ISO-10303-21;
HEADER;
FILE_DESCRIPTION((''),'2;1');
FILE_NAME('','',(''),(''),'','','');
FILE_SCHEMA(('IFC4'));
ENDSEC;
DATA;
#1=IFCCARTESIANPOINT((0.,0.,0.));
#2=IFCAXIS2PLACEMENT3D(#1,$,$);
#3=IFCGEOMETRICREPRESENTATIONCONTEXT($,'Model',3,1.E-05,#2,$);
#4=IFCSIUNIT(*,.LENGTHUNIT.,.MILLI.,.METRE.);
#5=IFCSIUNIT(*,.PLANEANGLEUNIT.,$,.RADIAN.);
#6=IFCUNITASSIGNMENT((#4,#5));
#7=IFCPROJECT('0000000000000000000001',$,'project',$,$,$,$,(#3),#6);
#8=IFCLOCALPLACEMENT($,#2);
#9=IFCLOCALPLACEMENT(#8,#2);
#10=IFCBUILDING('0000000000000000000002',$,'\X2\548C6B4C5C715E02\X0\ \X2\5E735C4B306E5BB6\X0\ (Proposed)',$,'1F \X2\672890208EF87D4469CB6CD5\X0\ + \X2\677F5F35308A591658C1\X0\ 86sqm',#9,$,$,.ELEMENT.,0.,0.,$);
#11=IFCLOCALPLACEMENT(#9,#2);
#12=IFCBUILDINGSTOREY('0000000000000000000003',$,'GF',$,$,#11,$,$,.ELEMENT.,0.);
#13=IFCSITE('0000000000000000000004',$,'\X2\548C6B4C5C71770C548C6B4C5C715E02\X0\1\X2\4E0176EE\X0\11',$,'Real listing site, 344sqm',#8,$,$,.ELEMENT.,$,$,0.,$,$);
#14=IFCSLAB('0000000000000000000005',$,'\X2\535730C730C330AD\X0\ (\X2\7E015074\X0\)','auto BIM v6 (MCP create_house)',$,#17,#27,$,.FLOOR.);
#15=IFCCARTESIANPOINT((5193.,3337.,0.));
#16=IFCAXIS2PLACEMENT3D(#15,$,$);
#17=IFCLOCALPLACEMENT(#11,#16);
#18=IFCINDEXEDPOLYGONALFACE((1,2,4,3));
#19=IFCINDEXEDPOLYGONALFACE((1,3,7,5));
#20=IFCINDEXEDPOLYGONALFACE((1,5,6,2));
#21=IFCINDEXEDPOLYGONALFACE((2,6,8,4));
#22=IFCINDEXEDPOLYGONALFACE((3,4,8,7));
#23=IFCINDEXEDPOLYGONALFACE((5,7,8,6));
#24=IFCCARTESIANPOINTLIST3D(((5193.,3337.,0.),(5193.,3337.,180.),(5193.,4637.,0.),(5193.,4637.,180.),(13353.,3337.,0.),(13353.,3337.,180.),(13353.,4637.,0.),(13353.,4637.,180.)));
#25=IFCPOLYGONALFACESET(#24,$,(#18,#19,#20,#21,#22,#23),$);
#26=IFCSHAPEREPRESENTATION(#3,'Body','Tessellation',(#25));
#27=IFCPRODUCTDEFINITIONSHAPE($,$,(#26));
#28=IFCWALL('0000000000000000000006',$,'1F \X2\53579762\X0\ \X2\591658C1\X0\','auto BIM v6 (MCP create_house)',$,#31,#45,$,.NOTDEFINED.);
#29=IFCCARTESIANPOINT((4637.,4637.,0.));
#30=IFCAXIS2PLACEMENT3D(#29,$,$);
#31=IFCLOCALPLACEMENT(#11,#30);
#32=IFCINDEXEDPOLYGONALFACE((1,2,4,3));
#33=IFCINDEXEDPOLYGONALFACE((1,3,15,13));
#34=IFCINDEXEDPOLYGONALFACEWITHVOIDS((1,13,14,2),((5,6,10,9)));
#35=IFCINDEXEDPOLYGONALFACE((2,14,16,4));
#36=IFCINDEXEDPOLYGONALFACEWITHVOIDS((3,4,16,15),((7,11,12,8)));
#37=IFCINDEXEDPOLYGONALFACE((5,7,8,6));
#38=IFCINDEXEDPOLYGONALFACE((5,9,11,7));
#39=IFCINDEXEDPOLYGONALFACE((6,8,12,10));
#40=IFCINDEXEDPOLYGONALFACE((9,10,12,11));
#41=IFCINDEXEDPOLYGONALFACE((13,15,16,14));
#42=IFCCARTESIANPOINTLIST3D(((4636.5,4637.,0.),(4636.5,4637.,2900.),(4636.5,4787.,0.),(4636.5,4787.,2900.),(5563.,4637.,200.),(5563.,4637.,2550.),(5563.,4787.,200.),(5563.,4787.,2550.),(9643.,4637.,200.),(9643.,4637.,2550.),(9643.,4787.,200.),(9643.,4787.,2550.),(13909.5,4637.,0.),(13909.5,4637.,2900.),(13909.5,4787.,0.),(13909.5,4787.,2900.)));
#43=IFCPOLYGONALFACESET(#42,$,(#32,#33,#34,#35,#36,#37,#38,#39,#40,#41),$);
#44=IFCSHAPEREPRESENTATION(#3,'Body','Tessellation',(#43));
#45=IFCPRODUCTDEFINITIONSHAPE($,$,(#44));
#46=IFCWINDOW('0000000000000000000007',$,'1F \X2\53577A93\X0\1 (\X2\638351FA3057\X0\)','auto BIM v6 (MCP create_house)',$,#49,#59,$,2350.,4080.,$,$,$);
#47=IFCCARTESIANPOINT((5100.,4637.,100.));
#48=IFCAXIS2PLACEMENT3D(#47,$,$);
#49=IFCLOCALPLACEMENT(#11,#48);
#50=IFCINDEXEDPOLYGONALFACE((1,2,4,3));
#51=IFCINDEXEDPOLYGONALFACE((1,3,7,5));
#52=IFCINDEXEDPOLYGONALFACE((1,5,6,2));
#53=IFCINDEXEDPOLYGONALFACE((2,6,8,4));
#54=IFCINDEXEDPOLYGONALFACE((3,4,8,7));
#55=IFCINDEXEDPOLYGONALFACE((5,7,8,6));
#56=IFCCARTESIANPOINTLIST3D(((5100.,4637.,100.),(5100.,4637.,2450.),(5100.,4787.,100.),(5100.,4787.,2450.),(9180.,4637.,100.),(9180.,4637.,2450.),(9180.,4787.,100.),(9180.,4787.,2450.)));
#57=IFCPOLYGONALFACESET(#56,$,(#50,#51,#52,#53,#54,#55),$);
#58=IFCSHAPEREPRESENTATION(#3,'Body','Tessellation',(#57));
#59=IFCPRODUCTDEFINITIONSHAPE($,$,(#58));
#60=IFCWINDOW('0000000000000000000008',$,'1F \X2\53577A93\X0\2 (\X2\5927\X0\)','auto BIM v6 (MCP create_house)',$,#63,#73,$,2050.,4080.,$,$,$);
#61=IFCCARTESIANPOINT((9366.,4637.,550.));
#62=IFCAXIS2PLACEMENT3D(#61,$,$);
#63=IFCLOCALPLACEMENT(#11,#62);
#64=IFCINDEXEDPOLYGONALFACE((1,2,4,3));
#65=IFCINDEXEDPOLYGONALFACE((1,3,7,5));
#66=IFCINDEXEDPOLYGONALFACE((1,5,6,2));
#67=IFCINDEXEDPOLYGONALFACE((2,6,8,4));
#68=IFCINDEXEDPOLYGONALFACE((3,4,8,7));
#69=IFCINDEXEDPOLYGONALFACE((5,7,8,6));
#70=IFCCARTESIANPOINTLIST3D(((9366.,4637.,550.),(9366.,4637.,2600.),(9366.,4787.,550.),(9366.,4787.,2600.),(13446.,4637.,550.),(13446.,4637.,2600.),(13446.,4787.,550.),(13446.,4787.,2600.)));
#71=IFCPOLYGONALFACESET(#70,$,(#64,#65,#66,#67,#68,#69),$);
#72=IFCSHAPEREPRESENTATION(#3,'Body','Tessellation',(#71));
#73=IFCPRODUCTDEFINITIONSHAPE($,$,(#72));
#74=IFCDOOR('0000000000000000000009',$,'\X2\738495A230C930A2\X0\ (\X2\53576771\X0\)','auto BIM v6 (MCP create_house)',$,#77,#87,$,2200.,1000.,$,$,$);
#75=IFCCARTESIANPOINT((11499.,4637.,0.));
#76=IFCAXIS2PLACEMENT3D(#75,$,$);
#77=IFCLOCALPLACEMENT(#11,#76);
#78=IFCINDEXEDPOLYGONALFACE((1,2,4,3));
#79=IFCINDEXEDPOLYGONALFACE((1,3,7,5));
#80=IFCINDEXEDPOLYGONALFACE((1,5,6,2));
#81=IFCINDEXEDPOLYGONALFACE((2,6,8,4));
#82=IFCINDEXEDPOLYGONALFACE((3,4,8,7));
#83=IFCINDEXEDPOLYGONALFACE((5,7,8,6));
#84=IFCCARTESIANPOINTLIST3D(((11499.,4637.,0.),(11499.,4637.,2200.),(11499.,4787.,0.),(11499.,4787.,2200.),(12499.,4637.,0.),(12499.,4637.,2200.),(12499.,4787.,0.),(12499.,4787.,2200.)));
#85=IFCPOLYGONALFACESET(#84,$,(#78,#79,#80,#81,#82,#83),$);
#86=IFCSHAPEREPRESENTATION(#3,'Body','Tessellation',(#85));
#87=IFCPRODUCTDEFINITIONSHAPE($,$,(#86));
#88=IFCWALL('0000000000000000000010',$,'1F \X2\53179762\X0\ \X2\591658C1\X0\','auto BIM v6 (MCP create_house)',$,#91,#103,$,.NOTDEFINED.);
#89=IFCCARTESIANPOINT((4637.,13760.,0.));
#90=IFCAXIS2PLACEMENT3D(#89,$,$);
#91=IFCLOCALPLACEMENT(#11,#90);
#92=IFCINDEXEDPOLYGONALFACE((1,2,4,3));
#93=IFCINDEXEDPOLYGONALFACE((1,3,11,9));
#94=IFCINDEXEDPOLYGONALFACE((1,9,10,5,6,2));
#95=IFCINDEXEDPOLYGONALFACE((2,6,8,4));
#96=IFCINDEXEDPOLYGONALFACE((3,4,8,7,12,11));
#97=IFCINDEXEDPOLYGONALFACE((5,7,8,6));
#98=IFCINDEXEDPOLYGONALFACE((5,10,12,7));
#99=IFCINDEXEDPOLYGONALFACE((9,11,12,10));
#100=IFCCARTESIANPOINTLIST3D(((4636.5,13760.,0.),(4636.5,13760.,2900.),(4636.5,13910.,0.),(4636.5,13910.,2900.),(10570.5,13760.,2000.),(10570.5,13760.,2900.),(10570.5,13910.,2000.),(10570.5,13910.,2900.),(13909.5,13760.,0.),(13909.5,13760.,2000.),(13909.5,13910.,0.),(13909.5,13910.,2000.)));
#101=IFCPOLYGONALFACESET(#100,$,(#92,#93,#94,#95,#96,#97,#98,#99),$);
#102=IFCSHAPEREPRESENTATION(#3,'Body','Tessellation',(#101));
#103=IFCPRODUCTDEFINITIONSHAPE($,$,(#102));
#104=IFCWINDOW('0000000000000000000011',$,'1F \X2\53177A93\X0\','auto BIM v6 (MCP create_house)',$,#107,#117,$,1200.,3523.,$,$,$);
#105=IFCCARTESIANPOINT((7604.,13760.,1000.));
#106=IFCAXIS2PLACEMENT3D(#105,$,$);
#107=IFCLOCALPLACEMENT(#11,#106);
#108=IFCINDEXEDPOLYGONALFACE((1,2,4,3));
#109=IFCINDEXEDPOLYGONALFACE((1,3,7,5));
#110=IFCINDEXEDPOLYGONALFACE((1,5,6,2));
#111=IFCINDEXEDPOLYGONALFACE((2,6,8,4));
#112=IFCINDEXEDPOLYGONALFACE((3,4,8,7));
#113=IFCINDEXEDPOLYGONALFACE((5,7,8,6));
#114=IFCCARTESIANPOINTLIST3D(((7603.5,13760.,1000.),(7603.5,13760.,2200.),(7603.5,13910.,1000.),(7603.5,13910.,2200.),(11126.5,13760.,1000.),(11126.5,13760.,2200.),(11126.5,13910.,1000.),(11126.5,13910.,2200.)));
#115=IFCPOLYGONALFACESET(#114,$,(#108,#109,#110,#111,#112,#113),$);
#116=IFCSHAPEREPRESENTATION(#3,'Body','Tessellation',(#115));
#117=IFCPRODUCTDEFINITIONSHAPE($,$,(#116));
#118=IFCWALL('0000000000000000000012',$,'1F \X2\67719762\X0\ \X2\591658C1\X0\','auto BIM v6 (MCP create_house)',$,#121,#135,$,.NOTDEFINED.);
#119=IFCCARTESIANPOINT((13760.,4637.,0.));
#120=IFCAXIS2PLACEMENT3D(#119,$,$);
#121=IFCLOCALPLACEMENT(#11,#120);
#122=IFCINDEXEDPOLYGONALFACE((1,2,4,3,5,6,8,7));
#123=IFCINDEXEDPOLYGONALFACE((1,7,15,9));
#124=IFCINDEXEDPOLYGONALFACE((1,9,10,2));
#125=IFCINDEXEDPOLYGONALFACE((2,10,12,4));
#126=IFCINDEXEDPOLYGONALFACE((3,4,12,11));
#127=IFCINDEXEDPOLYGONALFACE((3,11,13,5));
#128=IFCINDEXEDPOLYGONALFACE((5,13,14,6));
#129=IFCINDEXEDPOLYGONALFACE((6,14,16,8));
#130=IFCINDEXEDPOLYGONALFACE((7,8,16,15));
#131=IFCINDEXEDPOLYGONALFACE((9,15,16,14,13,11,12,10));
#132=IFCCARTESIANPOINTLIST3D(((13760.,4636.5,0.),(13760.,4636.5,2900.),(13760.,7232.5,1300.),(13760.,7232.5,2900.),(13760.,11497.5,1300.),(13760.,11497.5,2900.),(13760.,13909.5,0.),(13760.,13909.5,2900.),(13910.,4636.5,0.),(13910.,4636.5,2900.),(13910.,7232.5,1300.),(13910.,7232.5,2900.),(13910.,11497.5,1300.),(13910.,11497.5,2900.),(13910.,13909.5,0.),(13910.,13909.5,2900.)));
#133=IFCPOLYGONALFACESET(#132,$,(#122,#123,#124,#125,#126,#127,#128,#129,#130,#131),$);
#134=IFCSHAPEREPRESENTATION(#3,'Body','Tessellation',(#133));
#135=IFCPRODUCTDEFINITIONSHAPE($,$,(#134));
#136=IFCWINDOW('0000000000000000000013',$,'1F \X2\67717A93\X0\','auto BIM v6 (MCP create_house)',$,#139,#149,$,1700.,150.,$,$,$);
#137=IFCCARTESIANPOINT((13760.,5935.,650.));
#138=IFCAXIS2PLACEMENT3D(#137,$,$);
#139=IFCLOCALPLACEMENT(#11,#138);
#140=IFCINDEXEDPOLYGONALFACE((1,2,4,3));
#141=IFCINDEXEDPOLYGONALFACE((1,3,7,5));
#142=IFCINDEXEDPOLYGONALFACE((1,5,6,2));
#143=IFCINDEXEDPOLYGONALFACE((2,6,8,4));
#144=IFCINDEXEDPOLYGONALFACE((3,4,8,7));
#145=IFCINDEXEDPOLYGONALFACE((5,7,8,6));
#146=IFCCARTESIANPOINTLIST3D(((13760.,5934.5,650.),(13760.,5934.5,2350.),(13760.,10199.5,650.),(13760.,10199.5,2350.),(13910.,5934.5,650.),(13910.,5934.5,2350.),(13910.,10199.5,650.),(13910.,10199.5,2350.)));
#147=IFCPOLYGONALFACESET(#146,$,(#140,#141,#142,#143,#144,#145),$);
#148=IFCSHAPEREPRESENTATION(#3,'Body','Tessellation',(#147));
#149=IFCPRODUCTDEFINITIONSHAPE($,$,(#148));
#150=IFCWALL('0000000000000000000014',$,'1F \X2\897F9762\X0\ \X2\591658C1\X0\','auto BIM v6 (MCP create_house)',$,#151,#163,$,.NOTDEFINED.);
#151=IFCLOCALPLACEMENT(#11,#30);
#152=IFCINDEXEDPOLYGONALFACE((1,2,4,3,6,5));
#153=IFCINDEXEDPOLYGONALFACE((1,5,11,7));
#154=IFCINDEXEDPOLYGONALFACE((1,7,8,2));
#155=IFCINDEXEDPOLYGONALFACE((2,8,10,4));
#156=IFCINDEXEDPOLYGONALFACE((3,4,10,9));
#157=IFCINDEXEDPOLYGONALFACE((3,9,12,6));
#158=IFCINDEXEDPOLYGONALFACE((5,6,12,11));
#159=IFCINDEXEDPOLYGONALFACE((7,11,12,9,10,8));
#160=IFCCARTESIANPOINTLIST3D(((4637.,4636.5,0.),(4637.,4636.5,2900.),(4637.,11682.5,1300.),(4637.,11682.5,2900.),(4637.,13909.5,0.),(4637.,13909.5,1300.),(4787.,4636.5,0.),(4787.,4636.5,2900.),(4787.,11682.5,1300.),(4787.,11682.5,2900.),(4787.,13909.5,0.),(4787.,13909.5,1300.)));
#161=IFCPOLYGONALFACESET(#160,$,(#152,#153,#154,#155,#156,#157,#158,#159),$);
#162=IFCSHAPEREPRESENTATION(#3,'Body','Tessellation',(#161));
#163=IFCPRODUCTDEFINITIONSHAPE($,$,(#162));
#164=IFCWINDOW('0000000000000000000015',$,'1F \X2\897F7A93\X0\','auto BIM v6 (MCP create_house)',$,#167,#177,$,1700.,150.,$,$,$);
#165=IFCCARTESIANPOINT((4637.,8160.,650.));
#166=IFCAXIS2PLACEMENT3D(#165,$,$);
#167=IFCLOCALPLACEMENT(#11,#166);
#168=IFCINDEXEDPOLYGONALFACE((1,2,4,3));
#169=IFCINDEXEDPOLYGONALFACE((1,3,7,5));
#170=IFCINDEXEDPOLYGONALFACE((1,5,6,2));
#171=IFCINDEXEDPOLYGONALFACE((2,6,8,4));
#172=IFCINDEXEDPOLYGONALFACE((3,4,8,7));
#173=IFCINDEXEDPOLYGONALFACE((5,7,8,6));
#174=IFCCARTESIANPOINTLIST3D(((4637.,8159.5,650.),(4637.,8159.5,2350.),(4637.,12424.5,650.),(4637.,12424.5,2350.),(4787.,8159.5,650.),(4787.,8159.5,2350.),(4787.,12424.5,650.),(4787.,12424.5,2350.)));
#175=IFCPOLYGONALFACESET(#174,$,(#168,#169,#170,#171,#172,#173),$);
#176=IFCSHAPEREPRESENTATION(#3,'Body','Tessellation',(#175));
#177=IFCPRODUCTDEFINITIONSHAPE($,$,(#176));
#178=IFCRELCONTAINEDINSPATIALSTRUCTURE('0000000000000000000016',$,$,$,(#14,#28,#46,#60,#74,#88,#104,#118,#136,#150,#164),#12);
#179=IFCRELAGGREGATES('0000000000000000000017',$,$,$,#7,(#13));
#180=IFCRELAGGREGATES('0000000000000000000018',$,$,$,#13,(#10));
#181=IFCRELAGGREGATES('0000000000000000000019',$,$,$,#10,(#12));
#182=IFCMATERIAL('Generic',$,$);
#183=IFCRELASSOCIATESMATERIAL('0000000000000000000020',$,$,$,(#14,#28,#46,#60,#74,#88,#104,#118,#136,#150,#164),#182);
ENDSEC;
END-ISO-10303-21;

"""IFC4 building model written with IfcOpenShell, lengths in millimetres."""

from ifc_helpers import new_model, si_unit, frame, frame_2d, origin, place, context, project, spatial, rectangle, extrude, material, element, fill, save


model = new_model("IFC4")

# Units and contexts
model_context = context("Model", 3, precision=1e-05, world=origin())
ifc_project = project(units=[si_unit("LENGTHUNIT", "METRE", prefix="MILLI"), si_unit("PLANEANGLEUNIT", "RADIAN")], contexts=[model_context])

# Site, building, storey
site_placement = place(None, origin())
site = spatial("IfcSite", under=ifc_project, at=site_placement, Name="和歌山県和歌山市1丁目11", ObjectType="Real listing site, 344sqm", CompositionType="ELEMENT", RefElevation=0.0)
building_placement = place(site_placement, origin())
building = spatial("IfcBuilding", under=site, at=building_placement, Name="和歌山市 平屋の家 (Proposed)", ObjectType="1F 木造軸組構法 + 板張り外壁 86sqm", CompositionType="ELEMENT", ElevationOfRefHeight=0.0, ElevationOfTerrain=0.0)
storey_placement = place(building_placement, origin())
storey = spatial("IfcBuildingStorey", under=building, at=storey_placement, Name="GF", CompositionType="ELEMENT", Elevation=0.0)

# Slab
ifc_material = material(Name="Generic")
slab_1_placement = place(storey_placement, frame((5193.0, 3337.0, 0.0)))
element("IfcSlab", 1, at=slab_1_placement, inside=storey, material=ifc_material, Name="南デッキ (縁側)", Description="auto BIM v6 (MCP create_house)", PredefinedType="FLOOR", context=model_context, shape_type="SweptSolid", body=[
    extrude(rectangle(XDim=8160.0, YDim=1300.0, at=frame_2d((4080.0, 650.0))), frame((5193.0, 3337.0, 0.0)), (0.0, 0.0, 1.0), 180.0),
])

# Wall, openings, windows, door
wall_1_placement = place(storey_placement, frame((4637.0, 4637.0, 0.0)))
wall_1 = element("IfcWall", 2, at=wall_1_placement, inside=storey, material=ifc_material, Name="1F 南面 外壁", Description="auto BIM v6 (MCP create_house)", PredefinedType="NOTDEFINED", context=model_context, shape_type="SweptSolid", body=[
    extrude(rectangle(XDim=9273.0, YDim=150.0, at=frame_2d((4636.0, 75.0))), frame((4637.0, 4637.0, 0.0)), (0.0, 0.0, 1.0), 2900.0),
])
opening_1_placement = place(storey_placement, frame((5100.0, 4637.0, 100.0)))
opening_1 = element("IfcOpeningElement", 3, at=opening_1_placement, cuts=wall_1, PredefinedType="NOTDEFINED", context=model_context, shape_type="SweptSolid", body=[
    extrude(rectangle(XDim=4080.0, YDim=150.0, at=frame_2d((2040.0, 75.0))), frame((5100.0, 4637.0, 100.0)), (0.0, 0.0, 1.0), 2350.0),
])
opening_2_placement = place(storey_placement, frame((9366.0, 4637.0, 550.0)))
opening_2 = element("IfcOpeningElement", 4, at=opening_2_placement, cuts=wall_1, PredefinedType="NOTDEFINED", context=model_context, shape_type="SweptSolid", body=[
    extrude(rectangle(XDim=4080.0, YDim=150.0, at=frame_2d((2040.0, 75.0))), frame((9366.0, 4637.0, 550.0)), (0.0, 0.0, 1.0), 2050.0),
])
opening_3_placement = place(storey_placement, frame((11499.0, 4637.0, 0.0)))
opening_3 = element("IfcOpeningElement", 5, at=opening_3_placement, cuts=wall_1, PredefinedType="NOTDEFINED", context=model_context, shape_type="SweptSolid", body=[
    extrude(rectangle(XDim=1000.0, YDim=150.0, at=frame_2d((500.0, 75.0))), frame((11499.0, 4637.0, 0.0)), (0.0, 0.0, 1.0), 2200.0),
])
window_1_placement = place(storey_placement, frame((5100.0, 4637.0, 100.0)))
window_1 = element("IfcWindow", 6, at=window_1_placement, inside=storey, material=ifc_material, Name="1F 南窓1 (掃出し)", Description="auto BIM v6 (MCP create_house)", OverallHeight=2350.0, OverallWidth=4080.0, context=model_context, shape_type="SweptSolid", body=[
    extrude(rectangle(XDim=4080.0, YDim=150.0, at=frame_2d((2040.0, 75.0))), frame((5100.0, 4637.0, 100.0)), (0.0, 0.0, 1.0), 2350.0),
])
fill(opening_1, window_1)
window_2_placement = place(storey_placement, frame((9366.0, 4637.0, 550.0)))
window_2 = element("IfcWindow", 7, at=window_2_placement, inside=storey, material=ifc_material, Name="1F 南窓2 (大)", Description="auto BIM v6 (MCP create_house)", OverallHeight=2050.0, OverallWidth=4080.0, context=model_context, shape_type="SweptSolid", body=[
    extrude(rectangle(XDim=4080.0, YDim=150.0, at=frame_2d((2040.0, 75.0))), frame((9366.0, 4637.0, 550.0)), (0.0, 0.0, 1.0), 2050.0),
])
fill(opening_2, window_2)
door_placement = place(storey_placement, frame((11499.0, 4637.0, 0.0)))
door = element("IfcDoor", 8, at=door_placement, inside=storey, material=ifc_material, Name="玄関ドア (南東)", Description="auto BIM v6 (MCP create_house)", OverallHeight=2200.0, OverallWidth=1000.0, context=model_context, shape_type="SweptSolid", body=[
    extrude(rectangle(XDim=1000.0, YDim=150.0, at=frame_2d((500.0, 75.0))), frame((11499.0, 4637.0, 0.0)), (0.0, 0.0, 1.0), 2200.0),
])
fill(opening_3, door)

# Walls, openings, windows
wall_2_placement = place(storey_placement, frame((4637.0, 13760.0, 0.0)))
wall_2 = element("IfcWall", 9, at=wall_2_placement, inside=storey, material=ifc_material, Name="1F 北面 外壁", Description="auto BIM v6 (MCP create_house)", PredefinedType="NOTDEFINED", context=model_context, shape_type="SweptSolid", body=[
    extrude(rectangle(XDim=9273.0, YDim=150.0, at=frame_2d((4636.0, 75.0))), frame((4637.0, 13760.0, 0.0)), (0.0, 0.0, 1.0), 2900.0),
])
opening_4_placement = place(storey_placement, frame((7604.0, 13760.0, 1000.0)))
opening_4 = element("IfcOpeningElement", 10, at=opening_4_placement, cuts=wall_2, PredefinedType="NOTDEFINED", context=model_context, shape_type="SweptSolid", body=[
    extrude(rectangle(XDim=3523.0, YDim=150.0, at=frame_2d((1761.0, 75.0))), frame((7604.0, 13760.0, 1000.0)), (0.0, 0.0, 1.0), 1200.0),
])
window_3_placement = place(storey_placement, frame((7604.0, 13760.0, 1000.0)))
window_3 = element("IfcWindow", 11, at=window_3_placement, inside=storey, material=ifc_material, Name="1F 北窓", Description="auto BIM v6 (MCP create_house)", OverallHeight=1200.0, OverallWidth=3523.0, context=model_context, shape_type="SweptSolid", body=[
    extrude(rectangle(XDim=3523.0, YDim=150.0, at=frame_2d((1761.0, 75.0))), frame((7604.0, 13760.0, 1000.0)), (0.0, 0.0, 1.0), 1200.0),
])
fill(opening_4, window_3)
wall_3_placement = place(storey_placement, frame((13760.0, 4637.0, 0.0)))
wall_3 = element("IfcWall", 12, at=wall_3_placement, inside=storey, material=ifc_material, Name="1F 東面 外壁", Description="auto BIM v6 (MCP create_house)", PredefinedType="NOTDEFINED", context=model_context, shape_type="SweptSolid", body=[
    extrude(rectangle(XDim=150.0, YDim=9273.0, at=frame_2d((75.0, 4636.0))), frame((13760.0, 4637.0, 0.0)), (0.0, 0.0, 1.0), 2900.0),
])
opening_5_placement = place(storey_placement, frame((13760.0, 5935.0, 650.0)))
opening_5 = element("IfcOpeningElement", 13, at=opening_5_placement, cuts=wall_3, PredefinedType="NOTDEFINED", context=model_context, shape_type="SweptSolid", body=[
    extrude(rectangle(XDim=150.0, YDim=4265.0, at=frame_2d((75.0, 2132.0))), frame((13760.0, 5935.0, 650.0)), (0.0, 0.0, 1.0), 1700.0),
])
window_4_placement = place(storey_placement, frame((13760.0, 5935.0, 650.0)))
window_4 = element("IfcWindow", 14, at=window_4_placement, inside=storey, material=ifc_material, Name="1F 東窓", Description="auto BIM v6 (MCP create_house)", OverallHeight=1700.0, OverallWidth=150.0, context=model_context, shape_type="SweptSolid", body=[
    extrude(rectangle(XDim=150.0, YDim=4265.0, at=frame_2d((75.0, 2132.0))), frame((13760.0, 5935.0, 650.0)), (0.0, 0.0, 1.0), 1700.0),
])
fill(opening_5, window_4)
wall_4_placement = place(storey_placement, frame((4637.0, 4637.0, 0.0)))
wall_4 = element("IfcWall", 15, at=wall_4_placement, inside=storey, material=ifc_material, Name="1F 西面 外壁", Description="auto BIM v6 (MCP create_house)", PredefinedType="NOTDEFINED", context=model_context, shape_type="SweptSolid", body=[
    extrude(rectangle(XDim=150.0, YDim=9273.0, at=frame_2d((75.0, 4636.0))), frame((4637.0, 4637.0, 0.0)), (0.0, 0.0, 1.0), 2900.0),
])
opening_6_placement = place(storey_placement, frame((4637.0, 8160.0, 650.0)))
opening_6 = element("IfcOpeningElement", 16, at=opening_6_placement, cuts=wall_4, PredefinedType="NOTDEFINED", context=model_context, shape_type="SweptSolid", body=[
    extrude(rectangle(XDim=150.0, YDim=4265.0, at=frame_2d((75.0, 2132.0))), frame((4637.0, 8160.0, 650.0)), (0.0, 0.0, 1.0), 1700.0),
])
window_5_placement = place(storey_placement, frame((4637.0, 8160.0, 650.0)))
window_5 = element("IfcWindow", 17, at=window_5_placement, inside=storey, material=ifc_material, Name="1F 西窓", Description="auto BIM v6 (MCP create_house)", OverallHeight=1700.0, OverallWidth=150.0, context=model_context, shape_type="SweptSolid", body=[
    extrude(rectangle(XDim=150.0, YDim=4265.0, at=frame_2d((75.0, 2132.0))), frame((4637.0, 8160.0, 650.0)), (0.0, 0.0, 1.0), 1700.0),
])
fill(opening_6, window_5)

save(model, "model.ifc")
